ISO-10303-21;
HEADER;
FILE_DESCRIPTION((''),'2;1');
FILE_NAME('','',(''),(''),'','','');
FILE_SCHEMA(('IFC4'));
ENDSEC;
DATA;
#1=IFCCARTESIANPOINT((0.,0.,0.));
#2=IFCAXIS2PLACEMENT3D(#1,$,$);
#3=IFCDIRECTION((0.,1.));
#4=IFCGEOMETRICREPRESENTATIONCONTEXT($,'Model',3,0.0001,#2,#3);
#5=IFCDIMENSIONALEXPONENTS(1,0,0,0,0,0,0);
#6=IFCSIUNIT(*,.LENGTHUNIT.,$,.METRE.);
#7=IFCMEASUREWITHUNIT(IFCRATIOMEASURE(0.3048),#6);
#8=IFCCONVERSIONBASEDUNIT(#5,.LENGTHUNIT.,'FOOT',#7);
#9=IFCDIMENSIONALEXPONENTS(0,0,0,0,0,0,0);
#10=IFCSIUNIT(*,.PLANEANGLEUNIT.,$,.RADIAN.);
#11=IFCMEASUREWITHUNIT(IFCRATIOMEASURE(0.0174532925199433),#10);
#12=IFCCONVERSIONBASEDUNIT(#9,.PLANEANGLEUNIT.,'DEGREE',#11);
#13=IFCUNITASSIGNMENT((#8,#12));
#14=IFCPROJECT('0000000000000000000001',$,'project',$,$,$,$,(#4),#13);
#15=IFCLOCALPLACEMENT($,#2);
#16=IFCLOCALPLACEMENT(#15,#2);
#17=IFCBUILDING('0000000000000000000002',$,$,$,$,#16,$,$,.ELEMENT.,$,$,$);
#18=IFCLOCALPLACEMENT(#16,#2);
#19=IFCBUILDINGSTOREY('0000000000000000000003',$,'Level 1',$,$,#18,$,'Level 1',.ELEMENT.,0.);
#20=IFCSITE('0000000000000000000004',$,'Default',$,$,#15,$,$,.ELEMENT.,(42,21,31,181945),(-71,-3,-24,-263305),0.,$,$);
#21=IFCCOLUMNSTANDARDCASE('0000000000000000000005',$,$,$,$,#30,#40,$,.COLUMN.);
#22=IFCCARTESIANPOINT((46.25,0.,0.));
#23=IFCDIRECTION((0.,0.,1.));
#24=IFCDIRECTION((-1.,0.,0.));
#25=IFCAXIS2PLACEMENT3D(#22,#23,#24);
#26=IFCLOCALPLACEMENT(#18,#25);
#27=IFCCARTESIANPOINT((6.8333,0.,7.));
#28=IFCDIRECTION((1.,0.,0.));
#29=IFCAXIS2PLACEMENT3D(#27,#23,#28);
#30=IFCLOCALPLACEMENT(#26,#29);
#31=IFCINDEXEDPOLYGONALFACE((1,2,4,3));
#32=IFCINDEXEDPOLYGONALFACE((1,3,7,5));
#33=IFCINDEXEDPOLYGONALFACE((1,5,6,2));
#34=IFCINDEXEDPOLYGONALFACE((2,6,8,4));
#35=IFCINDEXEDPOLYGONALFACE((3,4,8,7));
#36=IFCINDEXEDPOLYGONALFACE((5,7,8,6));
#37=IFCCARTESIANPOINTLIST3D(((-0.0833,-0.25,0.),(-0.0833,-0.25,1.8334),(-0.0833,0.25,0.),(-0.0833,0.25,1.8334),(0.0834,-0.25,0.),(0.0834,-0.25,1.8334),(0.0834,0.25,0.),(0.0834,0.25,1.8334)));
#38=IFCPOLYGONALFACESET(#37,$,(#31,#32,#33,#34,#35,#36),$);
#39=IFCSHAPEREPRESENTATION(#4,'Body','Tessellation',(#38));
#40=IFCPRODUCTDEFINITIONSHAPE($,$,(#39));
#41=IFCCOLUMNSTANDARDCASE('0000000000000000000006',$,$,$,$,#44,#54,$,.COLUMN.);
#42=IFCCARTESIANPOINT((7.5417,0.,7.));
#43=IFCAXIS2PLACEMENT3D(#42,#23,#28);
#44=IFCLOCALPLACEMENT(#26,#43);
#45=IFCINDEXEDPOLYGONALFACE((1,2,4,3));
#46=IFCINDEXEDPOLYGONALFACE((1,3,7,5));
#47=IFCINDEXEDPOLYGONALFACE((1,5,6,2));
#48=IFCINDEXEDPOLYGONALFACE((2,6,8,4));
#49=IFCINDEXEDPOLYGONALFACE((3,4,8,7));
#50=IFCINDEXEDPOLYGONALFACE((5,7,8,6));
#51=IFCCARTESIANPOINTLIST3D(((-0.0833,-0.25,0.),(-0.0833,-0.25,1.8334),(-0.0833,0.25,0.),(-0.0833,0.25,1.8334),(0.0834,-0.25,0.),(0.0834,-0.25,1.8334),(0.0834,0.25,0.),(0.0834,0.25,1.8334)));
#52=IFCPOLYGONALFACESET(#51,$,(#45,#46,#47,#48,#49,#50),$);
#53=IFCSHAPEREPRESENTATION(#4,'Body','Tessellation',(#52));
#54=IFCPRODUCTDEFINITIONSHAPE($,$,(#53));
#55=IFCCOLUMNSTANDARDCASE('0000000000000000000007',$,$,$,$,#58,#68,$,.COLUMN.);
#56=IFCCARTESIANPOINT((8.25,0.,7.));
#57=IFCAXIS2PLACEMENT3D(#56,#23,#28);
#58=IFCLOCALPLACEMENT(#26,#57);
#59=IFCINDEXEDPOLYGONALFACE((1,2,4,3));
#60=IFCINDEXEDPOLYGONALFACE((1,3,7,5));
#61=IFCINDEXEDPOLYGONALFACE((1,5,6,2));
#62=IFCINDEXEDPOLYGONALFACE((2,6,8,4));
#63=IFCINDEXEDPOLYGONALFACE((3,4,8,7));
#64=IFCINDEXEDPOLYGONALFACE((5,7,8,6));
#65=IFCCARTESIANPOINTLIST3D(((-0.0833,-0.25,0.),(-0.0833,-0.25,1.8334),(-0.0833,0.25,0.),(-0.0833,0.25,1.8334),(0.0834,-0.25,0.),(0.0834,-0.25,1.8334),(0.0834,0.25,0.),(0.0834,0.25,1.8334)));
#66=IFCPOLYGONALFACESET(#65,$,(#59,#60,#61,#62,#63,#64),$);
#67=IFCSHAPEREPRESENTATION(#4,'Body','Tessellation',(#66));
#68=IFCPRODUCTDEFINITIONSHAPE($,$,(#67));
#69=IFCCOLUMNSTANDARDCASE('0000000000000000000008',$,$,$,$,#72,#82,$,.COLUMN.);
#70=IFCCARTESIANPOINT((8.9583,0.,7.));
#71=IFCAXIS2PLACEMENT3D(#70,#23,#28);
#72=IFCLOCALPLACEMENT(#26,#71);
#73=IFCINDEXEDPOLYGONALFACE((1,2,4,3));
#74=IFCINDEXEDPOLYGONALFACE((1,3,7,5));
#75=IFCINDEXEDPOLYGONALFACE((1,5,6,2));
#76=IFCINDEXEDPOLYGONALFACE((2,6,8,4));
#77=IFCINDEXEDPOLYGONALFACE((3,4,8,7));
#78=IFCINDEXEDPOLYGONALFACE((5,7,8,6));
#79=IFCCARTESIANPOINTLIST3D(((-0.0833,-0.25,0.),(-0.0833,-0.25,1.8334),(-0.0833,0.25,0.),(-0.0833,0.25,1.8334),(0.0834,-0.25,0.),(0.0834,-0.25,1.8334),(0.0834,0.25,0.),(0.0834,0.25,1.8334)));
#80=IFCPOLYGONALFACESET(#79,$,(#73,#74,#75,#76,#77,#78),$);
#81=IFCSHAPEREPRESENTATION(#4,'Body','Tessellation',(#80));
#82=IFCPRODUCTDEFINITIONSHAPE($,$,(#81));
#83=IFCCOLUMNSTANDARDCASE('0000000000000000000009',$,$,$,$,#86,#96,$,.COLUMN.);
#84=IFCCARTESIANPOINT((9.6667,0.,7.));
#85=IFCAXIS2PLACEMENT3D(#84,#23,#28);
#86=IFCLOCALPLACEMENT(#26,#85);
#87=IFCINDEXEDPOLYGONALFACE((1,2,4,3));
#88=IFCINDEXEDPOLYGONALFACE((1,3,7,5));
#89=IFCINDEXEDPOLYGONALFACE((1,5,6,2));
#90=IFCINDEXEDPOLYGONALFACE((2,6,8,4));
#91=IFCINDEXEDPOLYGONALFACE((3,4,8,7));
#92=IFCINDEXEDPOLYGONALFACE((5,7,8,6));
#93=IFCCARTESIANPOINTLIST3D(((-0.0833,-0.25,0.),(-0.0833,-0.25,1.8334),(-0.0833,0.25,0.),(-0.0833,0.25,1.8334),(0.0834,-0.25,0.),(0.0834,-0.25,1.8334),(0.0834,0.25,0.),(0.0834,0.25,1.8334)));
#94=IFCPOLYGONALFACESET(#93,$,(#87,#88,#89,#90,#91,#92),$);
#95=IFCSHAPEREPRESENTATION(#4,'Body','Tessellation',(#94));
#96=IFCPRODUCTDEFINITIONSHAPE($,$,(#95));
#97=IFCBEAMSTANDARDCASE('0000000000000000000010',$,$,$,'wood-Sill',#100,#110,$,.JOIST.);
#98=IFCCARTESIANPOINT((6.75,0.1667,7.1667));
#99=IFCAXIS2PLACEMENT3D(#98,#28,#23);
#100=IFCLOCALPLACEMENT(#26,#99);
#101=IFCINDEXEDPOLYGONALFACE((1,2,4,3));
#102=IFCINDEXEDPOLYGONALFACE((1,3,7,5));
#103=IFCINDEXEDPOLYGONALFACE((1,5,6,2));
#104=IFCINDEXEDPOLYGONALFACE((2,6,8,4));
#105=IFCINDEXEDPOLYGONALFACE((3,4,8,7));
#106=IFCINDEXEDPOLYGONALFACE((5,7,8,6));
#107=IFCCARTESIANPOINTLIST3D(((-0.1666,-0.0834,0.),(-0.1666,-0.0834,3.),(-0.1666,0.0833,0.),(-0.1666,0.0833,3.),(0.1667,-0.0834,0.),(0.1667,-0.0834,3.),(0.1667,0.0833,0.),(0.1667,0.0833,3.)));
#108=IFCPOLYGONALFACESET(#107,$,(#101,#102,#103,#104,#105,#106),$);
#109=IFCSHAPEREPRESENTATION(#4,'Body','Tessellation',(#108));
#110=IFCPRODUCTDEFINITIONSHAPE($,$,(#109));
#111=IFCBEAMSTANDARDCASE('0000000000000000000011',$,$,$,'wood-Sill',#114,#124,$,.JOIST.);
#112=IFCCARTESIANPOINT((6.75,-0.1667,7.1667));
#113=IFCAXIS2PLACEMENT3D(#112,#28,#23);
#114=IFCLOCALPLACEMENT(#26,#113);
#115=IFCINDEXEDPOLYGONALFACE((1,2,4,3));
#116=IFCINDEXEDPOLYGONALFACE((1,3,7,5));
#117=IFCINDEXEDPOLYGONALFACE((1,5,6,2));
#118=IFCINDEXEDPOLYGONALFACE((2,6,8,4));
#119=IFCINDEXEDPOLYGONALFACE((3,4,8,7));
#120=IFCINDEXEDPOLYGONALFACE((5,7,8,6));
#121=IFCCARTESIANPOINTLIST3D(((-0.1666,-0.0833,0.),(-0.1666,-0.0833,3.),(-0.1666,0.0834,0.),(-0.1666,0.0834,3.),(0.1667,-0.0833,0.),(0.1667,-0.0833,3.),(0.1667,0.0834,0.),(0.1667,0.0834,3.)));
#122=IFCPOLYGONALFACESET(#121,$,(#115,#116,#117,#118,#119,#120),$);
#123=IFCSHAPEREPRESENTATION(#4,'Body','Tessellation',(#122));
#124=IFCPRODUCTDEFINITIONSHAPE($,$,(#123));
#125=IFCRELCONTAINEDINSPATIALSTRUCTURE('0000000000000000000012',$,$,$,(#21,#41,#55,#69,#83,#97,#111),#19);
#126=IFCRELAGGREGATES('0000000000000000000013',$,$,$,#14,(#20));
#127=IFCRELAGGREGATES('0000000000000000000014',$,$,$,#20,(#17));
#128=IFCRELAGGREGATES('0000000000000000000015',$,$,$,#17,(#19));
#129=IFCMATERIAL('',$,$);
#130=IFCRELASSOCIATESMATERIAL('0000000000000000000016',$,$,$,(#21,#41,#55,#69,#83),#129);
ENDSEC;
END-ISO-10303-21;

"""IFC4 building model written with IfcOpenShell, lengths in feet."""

from ifc_helpers import new_model, entity, si_unit, converted_unit, direction, frame, origin, origin_with_axes, place, context, project, spatial, rectangle, extrude, material, element, save


model = new_model("IFC4")

# Units and contexts
model_context = context("Model", 3, precision=0.0001, world=origin(), true_north=direction((0.0, 1.0)))
ifc_project = project(units=[converted_unit("LENGTHUNIT", "FOOT", entity("IfcRatioMeasure", 0.3048), si_unit("LENGTHUNIT", "METRE"), dimensions=[1, 0, 0, 0, 0, 0, 0]), converted_unit("PLANEANGLEUNIT", "DEGREE", entity("IfcRatioMeasure", 0.0174532925199433), si_unit("PLANEANGLEUNIT", "RADIAN"), dimensions=[0, 0, 0, 0, 0, 0, 0])], contexts=[model_context])

# Site, building, storey
site_placement = place(None, origin())
site = spatial("IfcSite", under=ifc_project, at=site_placement, Name="Default", CompositionType="ELEMENT", RefLatitude=(42, 21, 31, 181945), RefLongitude=(-71, -3, -24, -263305), RefElevation=0.0)
building_placement = place(site_placement, origin())
building = spatial("IfcBuilding", under=site, at=building_placement, CompositionType="ELEMENT")
storey_placement = place(building_placement, origin())
storey = spatial("IfcBuildingStorey", under=building, at=storey_placement, Name="Level 1", LongName="Level 1", CompositionType="ELEMENT", Elevation=0.0)

# Columns
placement = place(storey_placement, frame((46.25, 0.0, 0.0), z_axis=(0.0, 0.0, 1.0), x_axis=(-1.0, 0.0, 0.0)))
ifc_material_1 = material(Name="")
for number, where, z_axis, x_axis in (
    (1, (6.8333, 0.0, 7.0), (0.0, 0.0, 1.0), (1.0, 0.0, 0.0)),
    (2, (7.5417, 0.0, 7.0), (0.0, 0.0, 1.0), (1.0, 0.0, 0.0)),
    (3, (8.25, 0.0, 7.0), (0.0, 0.0, 1.0), (1.0, 0.0, 0.0)),
    (4, (8.9583, 0.0, 7.0), (0.0, 0.0, 1.0), (1.0, 0.0, 0.0)),
    (5, (9.6667, 0.0, 7.0), (0.0, 0.0, 1.0), (1.0, 0.0, 0.0)),
):
    element("IfcColumnStandardCase", number, at=place(placement, frame(where, z_axis=z_axis, x_axis=x_axis)), inside=storey, material=ifc_material_1, PredefinedType="COLUMN", context=model_context, shape_type="SweptSolid", body=[
        extrude(rectangle(XDim=0.1667, YDim=0.5), origin(), (0.0, 0.0, 1.0), 1.8334),
    ])

# Beams
for number, where, z_axis, x_axis in (
    (6, (6.75, 0.1667, 7.1667), (1.0, 0.0, 0.0), (0.0, 0.0, 1.0)),
    (7, (6.75, -0.1667, 7.1667), (1.0, 0.0, 0.0), (0.0, 0.0, 1.0)),
):
    element("IfcBeamStandardCase", number, at=place(placement, frame(where, z_axis=z_axis, x_axis=x_axis)), inside=storey, ObjectType="wood-Sill", PredefinedType="JOIST", context=model_context, shape_type="SweptSolid", body=[
        extrude(rectangle(XDim=0.3333, YDim=0.1667), origin_with_axes(), (0.0, 0.0, 1.0), 3.0),
    ])

save(model, "model.ifc")
